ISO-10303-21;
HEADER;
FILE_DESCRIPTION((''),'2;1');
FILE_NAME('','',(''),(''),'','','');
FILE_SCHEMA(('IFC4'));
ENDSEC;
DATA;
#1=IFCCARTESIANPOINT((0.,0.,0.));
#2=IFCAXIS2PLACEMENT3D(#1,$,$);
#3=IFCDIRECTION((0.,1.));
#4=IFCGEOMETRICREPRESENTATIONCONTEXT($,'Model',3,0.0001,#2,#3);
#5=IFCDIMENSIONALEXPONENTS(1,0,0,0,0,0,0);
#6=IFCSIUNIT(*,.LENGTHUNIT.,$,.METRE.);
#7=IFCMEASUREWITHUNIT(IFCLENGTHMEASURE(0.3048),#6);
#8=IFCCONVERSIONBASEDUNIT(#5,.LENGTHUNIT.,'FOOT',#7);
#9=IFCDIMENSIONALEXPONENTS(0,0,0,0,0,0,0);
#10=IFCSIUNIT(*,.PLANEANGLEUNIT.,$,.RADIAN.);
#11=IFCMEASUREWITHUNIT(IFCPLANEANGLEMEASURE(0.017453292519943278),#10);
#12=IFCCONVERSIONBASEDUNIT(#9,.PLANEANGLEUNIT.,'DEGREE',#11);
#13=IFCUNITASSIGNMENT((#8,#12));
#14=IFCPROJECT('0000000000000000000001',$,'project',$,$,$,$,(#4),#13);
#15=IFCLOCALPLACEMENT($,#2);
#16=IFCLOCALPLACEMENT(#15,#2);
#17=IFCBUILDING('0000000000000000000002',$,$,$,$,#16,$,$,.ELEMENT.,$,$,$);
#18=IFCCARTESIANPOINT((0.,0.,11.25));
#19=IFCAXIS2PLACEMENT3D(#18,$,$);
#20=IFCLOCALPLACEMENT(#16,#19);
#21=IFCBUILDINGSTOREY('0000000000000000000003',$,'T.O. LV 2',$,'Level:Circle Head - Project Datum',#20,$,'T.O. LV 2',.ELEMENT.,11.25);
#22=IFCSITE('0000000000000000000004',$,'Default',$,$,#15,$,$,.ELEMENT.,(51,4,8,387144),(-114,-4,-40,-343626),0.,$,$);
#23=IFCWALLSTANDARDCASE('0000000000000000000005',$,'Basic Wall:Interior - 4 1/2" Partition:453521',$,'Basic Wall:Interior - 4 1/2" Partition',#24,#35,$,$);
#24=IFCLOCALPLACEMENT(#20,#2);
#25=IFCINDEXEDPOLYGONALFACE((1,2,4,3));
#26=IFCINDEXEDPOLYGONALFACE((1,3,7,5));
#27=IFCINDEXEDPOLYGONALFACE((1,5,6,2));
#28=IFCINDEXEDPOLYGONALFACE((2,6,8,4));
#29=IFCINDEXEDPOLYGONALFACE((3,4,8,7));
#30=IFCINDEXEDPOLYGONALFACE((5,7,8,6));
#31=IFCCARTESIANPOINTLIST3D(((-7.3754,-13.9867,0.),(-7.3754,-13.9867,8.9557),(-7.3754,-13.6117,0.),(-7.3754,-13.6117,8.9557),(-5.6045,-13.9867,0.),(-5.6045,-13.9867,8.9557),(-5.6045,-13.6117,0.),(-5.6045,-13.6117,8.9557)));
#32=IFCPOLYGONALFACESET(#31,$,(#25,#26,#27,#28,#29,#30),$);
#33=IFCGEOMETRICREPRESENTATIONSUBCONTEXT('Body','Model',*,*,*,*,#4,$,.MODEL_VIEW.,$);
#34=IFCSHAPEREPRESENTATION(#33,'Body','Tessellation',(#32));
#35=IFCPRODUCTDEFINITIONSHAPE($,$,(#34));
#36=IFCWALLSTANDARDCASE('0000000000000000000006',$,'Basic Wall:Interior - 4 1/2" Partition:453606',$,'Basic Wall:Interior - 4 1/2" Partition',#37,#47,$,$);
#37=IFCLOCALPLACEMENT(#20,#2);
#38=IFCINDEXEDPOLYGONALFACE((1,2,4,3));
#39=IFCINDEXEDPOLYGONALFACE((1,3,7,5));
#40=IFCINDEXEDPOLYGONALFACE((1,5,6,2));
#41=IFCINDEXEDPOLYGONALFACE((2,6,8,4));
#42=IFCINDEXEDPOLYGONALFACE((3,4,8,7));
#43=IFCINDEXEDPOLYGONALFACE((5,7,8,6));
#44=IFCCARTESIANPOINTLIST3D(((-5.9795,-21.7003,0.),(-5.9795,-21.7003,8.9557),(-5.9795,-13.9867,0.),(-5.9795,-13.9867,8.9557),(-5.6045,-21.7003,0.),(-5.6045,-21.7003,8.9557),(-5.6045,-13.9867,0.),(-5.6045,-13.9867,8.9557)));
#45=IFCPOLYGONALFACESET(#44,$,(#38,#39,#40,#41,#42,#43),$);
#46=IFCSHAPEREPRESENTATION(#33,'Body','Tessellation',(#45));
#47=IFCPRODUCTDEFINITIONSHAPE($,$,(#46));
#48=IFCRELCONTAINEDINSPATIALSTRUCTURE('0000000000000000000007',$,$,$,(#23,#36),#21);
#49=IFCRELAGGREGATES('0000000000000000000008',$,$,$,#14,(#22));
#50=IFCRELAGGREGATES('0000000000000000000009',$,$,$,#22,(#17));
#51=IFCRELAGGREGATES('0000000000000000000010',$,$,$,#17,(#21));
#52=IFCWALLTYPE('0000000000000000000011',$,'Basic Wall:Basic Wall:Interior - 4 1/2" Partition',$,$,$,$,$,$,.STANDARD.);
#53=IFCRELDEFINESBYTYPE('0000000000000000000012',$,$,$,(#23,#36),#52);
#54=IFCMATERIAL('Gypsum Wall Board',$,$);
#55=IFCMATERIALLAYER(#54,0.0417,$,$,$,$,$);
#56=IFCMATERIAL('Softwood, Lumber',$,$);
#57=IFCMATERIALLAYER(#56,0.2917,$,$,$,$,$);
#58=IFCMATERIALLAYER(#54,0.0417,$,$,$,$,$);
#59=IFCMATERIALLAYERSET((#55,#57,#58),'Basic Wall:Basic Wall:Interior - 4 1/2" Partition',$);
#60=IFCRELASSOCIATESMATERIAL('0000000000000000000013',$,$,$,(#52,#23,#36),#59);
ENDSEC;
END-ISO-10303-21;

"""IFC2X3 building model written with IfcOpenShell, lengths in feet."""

from ifc_helpers import new_model, entity, si_unit, converted_unit, direction, frame, frame_2d, origin, place, context, subcontext, project, spatial, rectangle, extrude, material, layer, layer_set, layer_usage, type_object, element, save


model = new_model("IFC2X3")

# Units and contexts
model_context = context("Model", 3, precision=0.0001, world=origin(), true_north=direction((0.0, 1.0)))
body_context = subcontext(model_context, "Body", "Model", "MODEL_VIEW")
ifc_project = project(units=[converted_unit("LENGTHUNIT", "FOOT", entity("IfcLengthMeasure", 0.3048), si_unit("LENGTHUNIT", "METRE"), dimensions=[1, 0, 0, 0, 0, 0, 0]), converted_unit("PLANEANGLEUNIT", "DEGREE", entity("IfcPlaneAngleMeasure", 0.017453292519943278), si_unit("PLANEANGLEUNIT", "RADIAN"), dimensions=[0, 0, 0, 0, 0, 0, 0])], contexts=[model_context])

# Site, building, storey
site_placement = place(None, origin())
site = spatial("IfcSite", under=ifc_project, at=site_placement, Name="Default", CompositionType="ELEMENT", RefLatitude=(51, 4, 8, 387144), RefLongitude=(-114, -4, -40, -343626), RefElevation=0.0)
building_placement = place(site_placement, origin())
building = spatial("IfcBuilding", under=site, at=building_placement, CompositionType="ELEMENT")
storey_placement = place(building_placement, frame((0.0, 0.0, 11.25)))
storey = spatial("IfcBuildingStorey", under=building, at=storey_placement, Name="T.O. LV 2", ObjectType="Level:Circle Head - Project Datum", LongName="T.O. LV 2", CompositionType="ELEMENT", Elevation=11.25)

# Shared definitions
ifc_material_1 = material(Name="Gypsum Wall Board")

# Shared definitions
ifc_layer_1 = layer(ifc_material_1, 0.0417)
ifc_material_2 = material(Name="Softwood, Lumber")
ifc_layer_2 = layer(ifc_material_2, 0.2917)
ifc_layer_3 = layer(ifc_material_1, 0.0417)
ifc_layer_set_1 = layer_set([ifc_layer_1, ifc_layer_2, ifc_layer_3], Name="Basic Wall:Basic Wall:Interior - 4 1/2\" Partition")
wall_type_1 = type_object("IfcWallType", Name="Basic Wall:Basic Wall:Interior - 4 1/2\" Partition", PredefinedType="STANDARD", material=ifc_layer_set_1)

# Walls
ifc_layer_usage_1 = layer_usage(ifc_layer_set_1, "AXIS2", "NEGATIVE", 0.1875)
wall_1_placement = place(storey_placement, frame((-7.3754, -13.7992, 0.0)))
element("IfcWallStandardCase", 1, at=wall_1_placement, inside=storey, type_object=wall_type_1, material=ifc_layer_usage_1, Name="Basic Wall:Interior - 4 1/2\" Partition:453521", ObjectType="Basic Wall:Interior - 4 1/2\" Partition", context=body_context, shape_type="SweptSolid", body=[
    extrude(rectangle(XDim=1.7708, YDim=0.375, at=frame_2d((0.8854, 0.0), x_axis=(-1.0, 0.0))), origin(), (0.0, 0.0, 1.0), 8.9557),
])
ifc_layer_usage_2 = layer_usage(ifc_layer_set_1, "AXIS2", "NEGATIVE", 0.1875)
wall_2_placement = place(storey_placement, frame((-5.792, -13.9867, 0.0), z_axis=(0.0, 0.0, 1.0), x_axis=(0.0, -1.0, 0.0)))
element("IfcWallStandardCase", 2, at=wall_2_placement, inside=storey, type_object=wall_type_1, material=ifc_layer_usage_2, Name="Basic Wall:Interior - 4 1/2\" Partition:453606", ObjectType="Basic Wall:Interior - 4 1/2\" Partition", context=body_context, shape_type="SweptSolid", body=[
    extrude(rectangle(XDim=7.7135, YDim=0.375, at=frame_2d((3.8568, 0.0), x_axis=(-1.0, 0.0))), origin(), (0.0, 0.0, 1.0), 8.9557),
])

save(model, "model.ifc")
